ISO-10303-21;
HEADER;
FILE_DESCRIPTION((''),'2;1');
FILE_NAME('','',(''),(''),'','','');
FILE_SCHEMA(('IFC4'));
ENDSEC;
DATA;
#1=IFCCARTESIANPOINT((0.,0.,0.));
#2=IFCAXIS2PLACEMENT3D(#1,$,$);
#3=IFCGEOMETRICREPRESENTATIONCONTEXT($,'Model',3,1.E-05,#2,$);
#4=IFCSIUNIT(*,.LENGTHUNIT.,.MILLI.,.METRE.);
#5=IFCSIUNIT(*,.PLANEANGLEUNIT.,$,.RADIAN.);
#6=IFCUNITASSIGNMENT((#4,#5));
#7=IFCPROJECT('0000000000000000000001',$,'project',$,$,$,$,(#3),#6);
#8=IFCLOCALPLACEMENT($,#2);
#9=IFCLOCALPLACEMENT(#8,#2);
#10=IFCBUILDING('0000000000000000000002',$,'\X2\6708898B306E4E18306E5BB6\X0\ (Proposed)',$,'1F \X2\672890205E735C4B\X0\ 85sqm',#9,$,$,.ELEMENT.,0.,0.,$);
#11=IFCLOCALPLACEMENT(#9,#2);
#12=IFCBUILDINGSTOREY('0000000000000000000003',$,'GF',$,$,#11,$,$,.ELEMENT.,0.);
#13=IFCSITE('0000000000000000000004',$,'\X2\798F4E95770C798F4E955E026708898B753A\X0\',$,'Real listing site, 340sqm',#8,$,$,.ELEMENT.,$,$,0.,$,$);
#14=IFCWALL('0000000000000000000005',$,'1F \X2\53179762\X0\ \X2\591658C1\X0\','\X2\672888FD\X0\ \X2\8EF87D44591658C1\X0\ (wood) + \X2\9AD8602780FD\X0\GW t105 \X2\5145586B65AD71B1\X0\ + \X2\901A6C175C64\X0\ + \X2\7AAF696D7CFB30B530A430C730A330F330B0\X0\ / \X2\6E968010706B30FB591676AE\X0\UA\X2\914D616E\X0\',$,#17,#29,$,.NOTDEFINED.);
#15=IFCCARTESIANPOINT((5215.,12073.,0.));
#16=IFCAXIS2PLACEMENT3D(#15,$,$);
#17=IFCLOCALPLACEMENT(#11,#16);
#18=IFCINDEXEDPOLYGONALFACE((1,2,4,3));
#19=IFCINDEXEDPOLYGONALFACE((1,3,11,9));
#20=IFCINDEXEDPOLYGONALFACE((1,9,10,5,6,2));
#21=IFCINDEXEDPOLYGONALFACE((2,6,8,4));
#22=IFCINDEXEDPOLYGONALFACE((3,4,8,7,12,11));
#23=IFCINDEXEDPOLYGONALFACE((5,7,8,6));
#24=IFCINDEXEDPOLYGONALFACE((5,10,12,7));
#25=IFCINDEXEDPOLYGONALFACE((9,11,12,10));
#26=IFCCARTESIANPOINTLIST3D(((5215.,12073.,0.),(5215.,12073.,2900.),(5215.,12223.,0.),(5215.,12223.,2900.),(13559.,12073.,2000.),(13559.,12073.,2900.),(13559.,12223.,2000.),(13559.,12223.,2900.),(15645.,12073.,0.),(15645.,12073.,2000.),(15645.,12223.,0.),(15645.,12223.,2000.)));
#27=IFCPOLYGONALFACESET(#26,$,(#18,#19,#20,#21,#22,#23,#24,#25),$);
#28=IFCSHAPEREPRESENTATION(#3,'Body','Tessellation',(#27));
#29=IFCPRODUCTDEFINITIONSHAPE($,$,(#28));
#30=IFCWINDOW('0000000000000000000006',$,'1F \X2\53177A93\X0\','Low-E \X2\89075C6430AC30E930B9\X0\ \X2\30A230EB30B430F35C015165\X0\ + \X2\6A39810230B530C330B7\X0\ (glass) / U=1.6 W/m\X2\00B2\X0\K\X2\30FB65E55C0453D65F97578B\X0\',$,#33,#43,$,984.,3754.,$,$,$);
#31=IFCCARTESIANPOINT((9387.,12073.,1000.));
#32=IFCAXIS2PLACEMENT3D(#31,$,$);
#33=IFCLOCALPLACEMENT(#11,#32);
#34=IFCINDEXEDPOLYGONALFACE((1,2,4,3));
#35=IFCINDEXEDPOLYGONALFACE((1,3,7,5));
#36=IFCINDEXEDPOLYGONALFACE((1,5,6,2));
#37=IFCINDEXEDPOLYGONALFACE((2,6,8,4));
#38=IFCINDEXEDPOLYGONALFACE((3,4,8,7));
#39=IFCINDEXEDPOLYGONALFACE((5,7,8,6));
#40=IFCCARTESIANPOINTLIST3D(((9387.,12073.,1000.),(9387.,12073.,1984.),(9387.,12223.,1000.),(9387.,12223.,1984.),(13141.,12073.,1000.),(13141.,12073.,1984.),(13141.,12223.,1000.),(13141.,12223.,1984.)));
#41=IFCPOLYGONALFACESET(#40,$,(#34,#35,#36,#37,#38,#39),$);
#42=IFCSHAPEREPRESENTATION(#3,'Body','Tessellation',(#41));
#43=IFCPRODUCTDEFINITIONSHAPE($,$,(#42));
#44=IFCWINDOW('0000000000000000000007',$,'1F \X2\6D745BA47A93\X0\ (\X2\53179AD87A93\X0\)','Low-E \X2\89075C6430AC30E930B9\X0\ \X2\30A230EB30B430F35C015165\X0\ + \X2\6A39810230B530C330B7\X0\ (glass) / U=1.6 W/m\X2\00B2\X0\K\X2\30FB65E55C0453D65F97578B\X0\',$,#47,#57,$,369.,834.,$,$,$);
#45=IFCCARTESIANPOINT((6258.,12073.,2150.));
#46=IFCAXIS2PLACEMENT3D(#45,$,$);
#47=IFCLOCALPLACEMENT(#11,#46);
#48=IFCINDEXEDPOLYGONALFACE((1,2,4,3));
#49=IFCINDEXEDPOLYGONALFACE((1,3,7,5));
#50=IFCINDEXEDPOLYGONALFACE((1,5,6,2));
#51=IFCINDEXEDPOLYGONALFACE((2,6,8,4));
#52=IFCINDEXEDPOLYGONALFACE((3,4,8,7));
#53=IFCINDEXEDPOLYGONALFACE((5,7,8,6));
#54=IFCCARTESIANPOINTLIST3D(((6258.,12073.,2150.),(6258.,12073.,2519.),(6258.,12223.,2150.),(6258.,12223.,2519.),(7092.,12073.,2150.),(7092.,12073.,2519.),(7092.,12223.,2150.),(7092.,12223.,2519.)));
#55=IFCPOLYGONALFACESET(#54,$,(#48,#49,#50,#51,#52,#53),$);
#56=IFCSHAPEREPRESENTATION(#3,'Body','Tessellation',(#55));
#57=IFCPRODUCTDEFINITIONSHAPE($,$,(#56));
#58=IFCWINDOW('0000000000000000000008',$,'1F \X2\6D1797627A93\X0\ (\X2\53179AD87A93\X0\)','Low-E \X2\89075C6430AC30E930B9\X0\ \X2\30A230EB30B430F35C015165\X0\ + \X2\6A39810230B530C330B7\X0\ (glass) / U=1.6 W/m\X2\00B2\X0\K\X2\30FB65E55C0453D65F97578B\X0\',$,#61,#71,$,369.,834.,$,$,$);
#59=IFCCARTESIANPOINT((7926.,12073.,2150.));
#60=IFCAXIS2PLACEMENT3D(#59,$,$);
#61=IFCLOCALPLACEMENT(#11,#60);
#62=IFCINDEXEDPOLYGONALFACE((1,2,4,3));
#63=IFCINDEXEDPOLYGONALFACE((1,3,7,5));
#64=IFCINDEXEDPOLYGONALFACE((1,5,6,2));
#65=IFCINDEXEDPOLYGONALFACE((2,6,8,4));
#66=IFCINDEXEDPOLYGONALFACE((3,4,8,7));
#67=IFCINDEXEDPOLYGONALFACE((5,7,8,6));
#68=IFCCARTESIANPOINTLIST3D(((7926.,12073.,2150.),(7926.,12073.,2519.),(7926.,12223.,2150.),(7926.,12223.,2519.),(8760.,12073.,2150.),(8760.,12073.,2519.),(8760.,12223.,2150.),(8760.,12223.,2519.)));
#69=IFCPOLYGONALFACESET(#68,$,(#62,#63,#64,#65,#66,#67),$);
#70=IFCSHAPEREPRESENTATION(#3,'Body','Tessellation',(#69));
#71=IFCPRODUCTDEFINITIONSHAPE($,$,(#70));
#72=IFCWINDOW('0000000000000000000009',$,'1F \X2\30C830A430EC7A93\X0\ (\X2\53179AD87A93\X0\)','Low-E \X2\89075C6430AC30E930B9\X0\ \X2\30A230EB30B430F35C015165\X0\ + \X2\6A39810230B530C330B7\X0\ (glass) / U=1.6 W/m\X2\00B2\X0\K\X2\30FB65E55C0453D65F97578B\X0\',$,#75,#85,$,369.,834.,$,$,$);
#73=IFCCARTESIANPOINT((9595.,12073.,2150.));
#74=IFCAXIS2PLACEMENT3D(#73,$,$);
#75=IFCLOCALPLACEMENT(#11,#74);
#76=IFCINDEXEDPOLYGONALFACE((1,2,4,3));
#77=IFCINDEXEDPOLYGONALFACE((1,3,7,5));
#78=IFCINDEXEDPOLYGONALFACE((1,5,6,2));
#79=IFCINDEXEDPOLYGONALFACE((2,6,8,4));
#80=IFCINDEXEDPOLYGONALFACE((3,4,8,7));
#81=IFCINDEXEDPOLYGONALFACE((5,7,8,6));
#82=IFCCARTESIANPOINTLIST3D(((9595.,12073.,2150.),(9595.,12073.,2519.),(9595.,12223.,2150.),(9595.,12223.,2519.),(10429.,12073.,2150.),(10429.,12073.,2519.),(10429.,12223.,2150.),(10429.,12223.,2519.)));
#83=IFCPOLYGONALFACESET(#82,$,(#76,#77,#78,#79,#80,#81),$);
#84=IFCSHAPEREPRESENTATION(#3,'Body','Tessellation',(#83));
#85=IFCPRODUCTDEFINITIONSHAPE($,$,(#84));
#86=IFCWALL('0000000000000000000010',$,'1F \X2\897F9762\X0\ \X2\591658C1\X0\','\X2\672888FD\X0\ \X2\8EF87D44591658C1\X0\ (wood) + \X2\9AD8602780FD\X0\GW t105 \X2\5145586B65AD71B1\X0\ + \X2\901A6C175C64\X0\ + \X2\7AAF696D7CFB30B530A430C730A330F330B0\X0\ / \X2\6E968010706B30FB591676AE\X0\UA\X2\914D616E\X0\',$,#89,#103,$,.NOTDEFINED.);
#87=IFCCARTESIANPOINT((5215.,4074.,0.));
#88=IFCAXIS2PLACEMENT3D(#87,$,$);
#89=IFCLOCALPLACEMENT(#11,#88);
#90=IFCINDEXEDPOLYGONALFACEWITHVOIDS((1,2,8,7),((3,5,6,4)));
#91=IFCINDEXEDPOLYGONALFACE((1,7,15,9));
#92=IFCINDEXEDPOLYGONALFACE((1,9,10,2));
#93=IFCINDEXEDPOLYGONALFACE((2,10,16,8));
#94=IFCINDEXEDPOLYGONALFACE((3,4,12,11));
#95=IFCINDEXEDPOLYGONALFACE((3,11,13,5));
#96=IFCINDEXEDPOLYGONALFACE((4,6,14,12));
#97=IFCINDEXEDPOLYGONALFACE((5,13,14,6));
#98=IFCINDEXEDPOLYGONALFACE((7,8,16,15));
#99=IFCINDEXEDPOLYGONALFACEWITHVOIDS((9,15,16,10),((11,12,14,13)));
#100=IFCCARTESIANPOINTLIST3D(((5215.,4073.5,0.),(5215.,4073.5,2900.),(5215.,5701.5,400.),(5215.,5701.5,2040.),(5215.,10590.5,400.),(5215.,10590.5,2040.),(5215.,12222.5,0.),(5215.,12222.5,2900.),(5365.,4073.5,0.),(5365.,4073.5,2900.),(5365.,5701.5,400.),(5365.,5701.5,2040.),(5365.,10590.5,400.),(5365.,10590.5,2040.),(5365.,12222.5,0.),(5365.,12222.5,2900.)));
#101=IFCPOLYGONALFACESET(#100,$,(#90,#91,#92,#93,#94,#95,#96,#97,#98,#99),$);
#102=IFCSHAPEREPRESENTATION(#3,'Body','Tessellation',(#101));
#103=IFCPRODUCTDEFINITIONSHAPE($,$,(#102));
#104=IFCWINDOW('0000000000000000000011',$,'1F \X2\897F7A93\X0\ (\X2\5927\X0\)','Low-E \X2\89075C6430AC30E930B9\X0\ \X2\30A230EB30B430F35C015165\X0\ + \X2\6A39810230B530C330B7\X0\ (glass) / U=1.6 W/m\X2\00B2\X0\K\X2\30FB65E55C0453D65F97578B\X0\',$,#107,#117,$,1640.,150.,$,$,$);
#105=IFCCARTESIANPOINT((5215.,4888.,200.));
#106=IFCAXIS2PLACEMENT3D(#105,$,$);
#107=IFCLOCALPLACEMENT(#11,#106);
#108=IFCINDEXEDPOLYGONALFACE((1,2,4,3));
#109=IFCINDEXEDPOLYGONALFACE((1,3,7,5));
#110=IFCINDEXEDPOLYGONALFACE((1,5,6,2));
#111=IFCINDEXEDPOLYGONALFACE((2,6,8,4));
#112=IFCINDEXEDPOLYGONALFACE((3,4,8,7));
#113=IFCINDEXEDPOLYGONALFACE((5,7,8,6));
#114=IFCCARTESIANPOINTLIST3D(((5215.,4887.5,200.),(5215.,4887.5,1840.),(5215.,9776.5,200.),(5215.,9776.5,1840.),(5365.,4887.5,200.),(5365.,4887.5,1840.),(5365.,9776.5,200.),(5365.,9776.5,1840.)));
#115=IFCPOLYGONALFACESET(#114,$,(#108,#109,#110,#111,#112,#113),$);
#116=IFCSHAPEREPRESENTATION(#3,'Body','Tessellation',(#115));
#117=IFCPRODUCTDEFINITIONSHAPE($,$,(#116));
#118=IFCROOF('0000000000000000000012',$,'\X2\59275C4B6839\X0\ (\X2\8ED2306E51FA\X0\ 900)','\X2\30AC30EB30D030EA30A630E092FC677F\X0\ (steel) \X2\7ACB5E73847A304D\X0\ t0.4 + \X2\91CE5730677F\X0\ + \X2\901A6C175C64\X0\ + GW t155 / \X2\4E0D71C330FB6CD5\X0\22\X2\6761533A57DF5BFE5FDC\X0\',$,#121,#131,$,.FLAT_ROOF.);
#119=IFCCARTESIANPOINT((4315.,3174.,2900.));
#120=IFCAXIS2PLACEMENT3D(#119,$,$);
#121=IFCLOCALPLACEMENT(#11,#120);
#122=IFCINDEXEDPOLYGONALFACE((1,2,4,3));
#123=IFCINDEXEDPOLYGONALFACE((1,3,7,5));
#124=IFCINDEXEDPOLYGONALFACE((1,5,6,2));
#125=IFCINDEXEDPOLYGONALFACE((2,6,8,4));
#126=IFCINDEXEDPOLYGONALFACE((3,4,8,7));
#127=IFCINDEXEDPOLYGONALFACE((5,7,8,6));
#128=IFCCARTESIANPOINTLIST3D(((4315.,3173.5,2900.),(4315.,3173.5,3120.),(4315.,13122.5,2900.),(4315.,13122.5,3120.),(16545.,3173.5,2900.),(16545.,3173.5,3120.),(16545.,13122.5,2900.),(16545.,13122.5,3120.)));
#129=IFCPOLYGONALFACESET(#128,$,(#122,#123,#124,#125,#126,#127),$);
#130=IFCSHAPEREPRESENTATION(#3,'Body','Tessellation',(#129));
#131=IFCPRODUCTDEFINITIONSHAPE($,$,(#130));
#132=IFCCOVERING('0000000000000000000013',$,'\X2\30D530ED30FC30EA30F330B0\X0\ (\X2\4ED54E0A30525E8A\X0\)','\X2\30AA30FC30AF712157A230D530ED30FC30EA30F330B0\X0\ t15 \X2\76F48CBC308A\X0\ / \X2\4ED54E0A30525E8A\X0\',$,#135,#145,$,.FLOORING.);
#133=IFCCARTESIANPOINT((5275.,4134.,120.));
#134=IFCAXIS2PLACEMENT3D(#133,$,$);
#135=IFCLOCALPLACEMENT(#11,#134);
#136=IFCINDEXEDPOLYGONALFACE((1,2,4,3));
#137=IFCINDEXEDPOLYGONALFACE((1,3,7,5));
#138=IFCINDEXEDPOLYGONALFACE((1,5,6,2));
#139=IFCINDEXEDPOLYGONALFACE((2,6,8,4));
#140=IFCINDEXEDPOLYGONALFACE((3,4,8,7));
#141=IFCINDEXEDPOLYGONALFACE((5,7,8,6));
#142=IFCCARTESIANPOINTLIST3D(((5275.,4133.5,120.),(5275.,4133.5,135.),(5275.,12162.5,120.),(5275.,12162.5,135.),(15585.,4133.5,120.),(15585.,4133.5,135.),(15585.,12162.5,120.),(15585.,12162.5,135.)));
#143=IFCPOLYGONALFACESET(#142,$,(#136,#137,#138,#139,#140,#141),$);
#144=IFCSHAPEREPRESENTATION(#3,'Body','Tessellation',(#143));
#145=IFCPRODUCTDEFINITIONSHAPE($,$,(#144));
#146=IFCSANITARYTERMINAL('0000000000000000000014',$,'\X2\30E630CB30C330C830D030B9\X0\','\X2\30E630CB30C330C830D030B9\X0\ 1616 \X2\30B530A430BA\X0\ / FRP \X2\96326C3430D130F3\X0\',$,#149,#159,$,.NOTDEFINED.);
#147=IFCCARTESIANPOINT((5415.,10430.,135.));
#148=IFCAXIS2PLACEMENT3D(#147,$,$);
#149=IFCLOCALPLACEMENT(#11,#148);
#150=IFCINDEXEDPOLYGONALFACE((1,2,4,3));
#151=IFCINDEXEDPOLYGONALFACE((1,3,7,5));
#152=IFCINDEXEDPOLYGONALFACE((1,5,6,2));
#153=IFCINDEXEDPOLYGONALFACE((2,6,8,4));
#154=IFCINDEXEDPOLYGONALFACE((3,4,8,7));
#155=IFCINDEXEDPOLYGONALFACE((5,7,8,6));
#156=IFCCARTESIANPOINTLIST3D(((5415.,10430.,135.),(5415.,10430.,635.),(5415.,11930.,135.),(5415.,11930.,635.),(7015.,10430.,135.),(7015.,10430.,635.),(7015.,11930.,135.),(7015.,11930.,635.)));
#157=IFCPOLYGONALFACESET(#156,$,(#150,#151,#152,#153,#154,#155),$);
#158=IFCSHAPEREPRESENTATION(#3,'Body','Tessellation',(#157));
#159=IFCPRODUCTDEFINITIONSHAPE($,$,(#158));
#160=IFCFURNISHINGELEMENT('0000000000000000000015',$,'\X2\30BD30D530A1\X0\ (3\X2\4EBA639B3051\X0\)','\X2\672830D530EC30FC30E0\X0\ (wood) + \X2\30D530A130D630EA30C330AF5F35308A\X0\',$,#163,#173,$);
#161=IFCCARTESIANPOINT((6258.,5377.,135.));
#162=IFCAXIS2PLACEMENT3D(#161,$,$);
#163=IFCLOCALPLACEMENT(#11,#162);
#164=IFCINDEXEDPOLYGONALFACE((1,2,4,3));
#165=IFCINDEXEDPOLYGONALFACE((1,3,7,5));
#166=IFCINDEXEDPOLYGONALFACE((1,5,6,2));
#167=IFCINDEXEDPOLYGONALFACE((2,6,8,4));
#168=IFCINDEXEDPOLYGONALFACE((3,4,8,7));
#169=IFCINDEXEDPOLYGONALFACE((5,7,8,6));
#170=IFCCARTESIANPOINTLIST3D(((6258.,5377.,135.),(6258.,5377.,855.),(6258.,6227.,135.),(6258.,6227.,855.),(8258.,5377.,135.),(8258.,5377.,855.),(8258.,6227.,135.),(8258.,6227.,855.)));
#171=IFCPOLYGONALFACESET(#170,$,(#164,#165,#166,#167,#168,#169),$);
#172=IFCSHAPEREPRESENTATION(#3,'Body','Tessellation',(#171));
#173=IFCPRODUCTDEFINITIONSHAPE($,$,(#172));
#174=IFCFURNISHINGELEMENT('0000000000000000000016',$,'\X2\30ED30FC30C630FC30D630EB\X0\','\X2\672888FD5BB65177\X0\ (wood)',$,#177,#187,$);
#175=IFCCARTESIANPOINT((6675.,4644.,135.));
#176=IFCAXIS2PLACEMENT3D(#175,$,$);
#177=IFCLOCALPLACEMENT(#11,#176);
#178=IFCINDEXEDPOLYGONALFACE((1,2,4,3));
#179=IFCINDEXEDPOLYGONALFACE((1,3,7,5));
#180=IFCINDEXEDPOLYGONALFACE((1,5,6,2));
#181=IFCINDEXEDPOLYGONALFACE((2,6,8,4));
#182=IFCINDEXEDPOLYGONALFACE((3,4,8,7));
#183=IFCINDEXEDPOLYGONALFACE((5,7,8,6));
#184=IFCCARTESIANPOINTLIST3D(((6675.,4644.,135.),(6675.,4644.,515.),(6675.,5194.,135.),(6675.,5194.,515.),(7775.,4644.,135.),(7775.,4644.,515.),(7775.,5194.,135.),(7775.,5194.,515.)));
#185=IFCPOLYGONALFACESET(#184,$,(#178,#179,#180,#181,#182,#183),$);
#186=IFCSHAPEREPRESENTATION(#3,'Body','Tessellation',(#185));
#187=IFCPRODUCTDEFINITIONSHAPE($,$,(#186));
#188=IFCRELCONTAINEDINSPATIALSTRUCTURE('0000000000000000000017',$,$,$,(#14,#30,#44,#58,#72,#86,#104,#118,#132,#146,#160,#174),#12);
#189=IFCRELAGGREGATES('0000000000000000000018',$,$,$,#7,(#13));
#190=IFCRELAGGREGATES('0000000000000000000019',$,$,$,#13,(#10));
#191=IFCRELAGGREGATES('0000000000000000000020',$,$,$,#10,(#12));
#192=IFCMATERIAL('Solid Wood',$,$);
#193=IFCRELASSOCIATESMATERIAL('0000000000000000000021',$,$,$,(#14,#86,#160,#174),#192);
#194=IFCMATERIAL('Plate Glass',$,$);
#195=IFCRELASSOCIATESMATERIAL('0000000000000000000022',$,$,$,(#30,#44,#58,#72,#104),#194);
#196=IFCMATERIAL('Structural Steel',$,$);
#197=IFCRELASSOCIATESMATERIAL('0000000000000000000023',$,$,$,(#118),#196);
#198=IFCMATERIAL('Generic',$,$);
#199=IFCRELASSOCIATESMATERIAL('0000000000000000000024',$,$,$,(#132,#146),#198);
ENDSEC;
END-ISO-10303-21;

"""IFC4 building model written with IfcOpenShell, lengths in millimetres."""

from ifc_helpers import new_model, si_unit, frame, frame_2d, origin, place, context, project, spatial, rectangle, extrude, material, element, fill, save


model = new_model("IFC4")

# Units and contexts
model_context = context("Model", 3, precision=1e-05, world=origin())
ifc_project = project(units=[si_unit("LENGTHUNIT", "METRE", prefix="MILLI"), si_unit("PLANEANGLEUNIT", "RADIAN")], contexts=[model_context])

# Site, building, storey
site_placement = place(None, origin())
site = spatial("IfcSite", under=ifc_project, at=site_placement, Name="福井県福井市月見町", ObjectType="Real listing site, 340sqm", CompositionType="ELEMENT", RefElevation=0.0)
building_placement = place(site_placement, origin())
building = spatial("IfcBuilding", under=site, at=building_placement, Name="月見の丘の家 (Proposed)", ObjectType="1F 木造平屋 85sqm", CompositionType="ELEMENT", ElevationOfRefHeight=0.0, ElevationOfTerrain=0.0)
storey_placement = place(building_placement, origin())
storey = spatial("IfcBuildingStorey", under=building, at=storey_placement, Name="GF", CompositionType="ELEMENT", Elevation=0.0)

# Shared definitions
ifc_material_1 = material(Name="Solid Wood")

# Shared definitions
ifc_material_2 = material(Name="Plate Glass")

# Wall, openings, windows
wall_1_placement = place(storey_placement, frame((5215.0, 12073.0, 0.0)))
wall_1 = element("IfcWall", 1, at=wall_1_placement, inside=storey, material=ifc_material_1, Name="1F 北面 外壁", Description="木製 軸組外壁 (wood) + 高性能GW t105 充填断熱 + 通気層 + 窯業系サイディング / 準耐火・外皮UA配慮", PredefinedType="NOTDEFINED", context=model_context, shape_type="SweptSolid", body=[
    extrude(rectangle(XDim=10430.0, YDim=150.0, at=frame_2d((5215.0, 75.0))), frame((5215.0, 12073.0, 0.0)), (0.0, 0.0, 1.0), 2900.0),
])
opening_1_placement = place(storey_placement, frame((9387.0, 12073.0, 1000.0)))
opening_1 = element("IfcOpeningElement", 2, at=opening_1_placement, cuts=wall_1, PredefinedType="NOTDEFINED", context=model_context, shape_type="SweptSolid", body=[
    extrude(rectangle(XDim=3754.0, YDim=150.0, at=frame_2d((1877.0, 75.0))), frame((9387.0, 12073.0, 1000.0)), (0.0, 0.0, 1.0), 984.0),
])
opening_2_placement = place(storey_placement, frame((6258.0, 12073.0, 2150.0)))
opening_2 = element("IfcOpeningElement", 3, at=opening_2_placement, cuts=wall_1, PredefinedType="NOTDEFINED", context=model_context, shape_type="SweptSolid", body=[
    extrude(rectangle(XDim=834.0, YDim=150.0, at=frame_2d((417.0, 75.0))), frame((6258.0, 12073.0, 2150.0)), (0.0, 0.0, 1.0), 369.0),
])
opening_3_placement = place(storey_placement, frame((7926.0, 12073.0, 2150.0)))
opening_3 = element("IfcOpeningElement", 4, at=opening_3_placement, cuts=wall_1, PredefinedType="NOTDEFINED", context=model_context, shape_type="SweptSolid", body=[
    extrude(rectangle(XDim=834.0, YDim=150.0, at=frame_2d((417.0, 75.0))), frame((7926.0, 12073.0, 2150.0)), (0.0, 0.0, 1.0), 369.0),
])
opening_4_placement = place(storey_placement, frame((9595.0, 12073.0, 2150.0)))
opening_4 = element("IfcOpeningElement", 5, at=opening_4_placement, cuts=wall_1, PredefinedType="NOTDEFINED", context=model_context, shape_type="SweptSolid", body=[
    extrude(rectangle(XDim=834.0, YDim=150.0, at=frame_2d((417.0, 75.0))), frame((9595.0, 12073.0, 2150.0)), (0.0, 0.0, 1.0), 369.0),
])
window_1_placement = place(storey_placement, frame((9387.0, 12073.0, 1000.0)))
window_1 = element("IfcWindow", 6, at=window_1_placement, inside=storey, material=ifc_material_2, Name="1F 北窓", Description="Low-E 複層ガラス アルゴン封入 + 樹脂サッシ (glass) / U=1.6 W/m²K・日射取得型", OverallHeight=984.0, OverallWidth=3754.0, context=model_context, shape_type="SweptSolid", body=[
    extrude(rectangle(XDim=3754.0, YDim=150.0, at=frame_2d((1877.0, 75.0))), frame((9387.0, 12073.0, 1000.0)), (0.0, 0.0, 1.0), 984.0),
])
fill(opening_1, window_1)
window_2_placement = place(storey_placement, frame((6258.0, 12073.0, 2150.0)))
window_2 = element("IfcWindow", 7, at=window_2_placement, inside=storey, material=ifc_material_2, Name="1F 浴室窓 (北高窓)", Description="Low-E 複層ガラス アルゴン封入 + 樹脂サッシ (glass) / U=1.6 W/m²K・日射取得型", OverallHeight=369.0, OverallWidth=834.0, context=model_context, shape_type="SweptSolid", body=[
    extrude(rectangle(XDim=834.0, YDim=150.0, at=frame_2d((417.0, 75.0))), frame((6258.0, 12073.0, 2150.0)), (0.0, 0.0, 1.0), 369.0),
])
fill(opening_2, window_2)
window_3_placement = place(storey_placement, frame((7926.0, 12073.0, 2150.0)))
window_3 = element("IfcWindow", 8, at=window_3_placement, inside=storey, material=ifc_material_2, Name="1F 洗面窓 (北高窓)", Description="Low-E 複層ガラス アルゴン封入 + 樹脂サッシ (glass) / U=1.6 W/m²K・日射取得型", OverallHeight=369.0, OverallWidth=834.0, context=model_context, shape_type="SweptSolid", body=[
    extrude(rectangle(XDim=834.0, YDim=150.0, at=frame_2d((417.0, 75.0))), frame((7926.0, 12073.0, 2150.0)), (0.0, 0.0, 1.0), 369.0),
])
fill(opening_3, window_3)
window_4_placement = place(storey_placement, frame((9595.0, 12073.0, 2150.0)))
window_4 = element("IfcWindow", 9, at=window_4_placement, inside=storey, material=ifc_material_2, Name="1F トイレ窓 (北高窓)", Description="Low-E 複層ガラス アルゴン封入 + 樹脂サッシ (glass) / U=1.6 W/m²K・日射取得型", OverallHeight=369.0, OverallWidth=834.0, context=model_context, shape_type="SweptSolid", body=[
    extrude(rectangle(XDim=834.0, YDim=150.0, at=frame_2d((417.0, 75.0))), frame((9595.0, 12073.0, 2150.0)), (0.0, 0.0, 1.0), 369.0),
])
fill(opening_4, window_4)

# Wall, opening, window
wall_2_placement = place(storey_placement, frame((5215.0, 4074.0, 0.0)))
wall_2 = element("IfcWall", 10, at=wall_2_placement, inside=storey, material=ifc_material_1, Name="1F 西面 外壁", Description="木製 軸組外壁 (wood) + 高性能GW t105 充填断熱 + 通気層 + 窯業系サイディング / 準耐火・外皮UA配慮", PredefinedType="NOTDEFINED", context=model_context, shape_type="SweptSolid", body=[
    extrude(rectangle(XDim=150.0, YDim=8149.0, at=frame_2d((75.0, 4074.0))), frame((5215.0, 4074.0, 0.0)), (0.0, 0.0, 1.0), 2900.0),
])
opening_5_placement = place(storey_placement, frame((5215.0, 4888.0, 200.0)))
opening_5 = element("IfcOpeningElement", 11, at=opening_5_placement, cuts=wall_2, PredefinedType="NOTDEFINED", context=model_context, shape_type="SweptSolid", body=[
    extrude(rectangle(XDim=150.0, YDim=4889.0, at=frame_2d((75.0, 2444.0))), frame((5215.0, 4888.0, 200.0)), (0.0, 0.0, 1.0), 1640.0),
])
window_5_placement = place(storey_placement, frame((5215.0, 4888.0, 200.0)))
window_5 = element("IfcWindow", 12, at=window_5_placement, inside=storey, material=ifc_material_2, Name="1F 西窓 (大)", Description="Low-E 複層ガラス アルゴン封入 + 樹脂サッシ (glass) / U=1.6 W/m²K・日射取得型", OverallHeight=1640.0, OverallWidth=150.0, context=model_context, shape_type="SweptSolid", body=[
    extrude(rectangle(XDim=150.0, YDim=4889.0, at=frame_2d((75.0, 2444.0))), frame((5215.0, 4888.0, 200.0)), (0.0, 0.0, 1.0), 1640.0),
])
fill(opening_5, window_5)

# Roof
ifc_material_3 = material(Name="Structural Steel")
roof_placement = place(storey_placement, frame((4315.0, 3174.0, 2900.0)))
element("IfcRoof", 13, at=roof_placement, inside=storey, material=ifc_material_3, Name="大屋根 (軒の出 900)", Description="ガルバリウム鋼板 (steel) 立平葺き t0.4 + 野地板 + 通気層 + GW t155 / 不燃・法22条区域対応", PredefinedType="FLAT_ROOF", context=model_context, shape_type="SweptSolid", body=[
    extrude(rectangle(XDim=12230.0, YDim=9949.0, at=frame_2d((6115.0, 4974.0))), frame((4315.0, 3174.0, 2900.0)), (0.0, 0.0, 1.0), 220.0),
])

# Covering
ifc_material_4 = material(Name="Generic")
covering_placement = place(storey_placement, frame((5275.0, 4134.0, 120.0)))
element("IfcCovering", 14, at=covering_placement, inside=storey, material=ifc_material_4, Name="フローリング (仕上げ床)", Description="オーク無垢フローリング t15 直貼り / 仕上げ床", PredefinedType="FLOORING", context=model_context, shape_type="SweptSolid", body=[
    extrude(rectangle(XDim=10310.0, YDim=8029.0, at=frame_2d((5155.0, 4014.0))), frame((5275.0, 4134.0, 120.0)), (0.0, 0.0, 1.0), 15.0),
])

# Sanitary terminal
sanitary_terminal_placement = place(storey_placement, frame((5415.0, 10430.0, 135.0)))
element("IfcSanitaryTerminal", 15, at=sanitary_terminal_placement, inside=storey, material=ifc_material_4, Name="ユニットバス", Description="ユニットバス 1616 サイズ / FRP 防水パン", PredefinedType="NOTDEFINED", context=model_context, shape_type="SweptSolid", body=[
    extrude(rectangle(XDim=1600.0, YDim=1500.0, at=frame_2d((800.0, 750.0))), frame((5415.0, 10430.0, 135.0)), (0.0, 0.0, 1.0), 500.0),
])

# Furnishing elements
furnishing_1_placement = place(storey_placement, frame((6258.0, 5377.0, 135.0)))
element("IfcFurnishingElement", 16, at=furnishing_1_placement, inside=storey, material=ifc_material_1, Name="ソファ (3人掛け)", Description="木フレーム (wood) + ファブリック張り", context=model_context, shape_type="SweptSolid", body=[
    extrude(rectangle(XDim=2000.0, YDim=850.0, at=frame_2d((1000.0, 425.0))), frame((6258.0, 5377.0, 135.0)), (0.0, 0.0, 1.0), 720.0),
])
furnishing_2_placement = place(storey_placement, frame((6675.0, 4644.0, 135.0)))
element("IfcFurnishingElement", 17, at=furnishing_2_placement, inside=storey, material=ifc_material_1, Name="ローテーブル", Description="木製家具 (wood)", context=model_context, shape_type="SweptSolid", body=[
    extrude(rectangle(XDim=1100.0, YDim=550.0, at=frame_2d((550.0, 275.0))), frame((6675.0, 4644.0, 135.0)), (0.0, 0.0, 1.0), 380.0),
])

save(model, "model.ifc")
